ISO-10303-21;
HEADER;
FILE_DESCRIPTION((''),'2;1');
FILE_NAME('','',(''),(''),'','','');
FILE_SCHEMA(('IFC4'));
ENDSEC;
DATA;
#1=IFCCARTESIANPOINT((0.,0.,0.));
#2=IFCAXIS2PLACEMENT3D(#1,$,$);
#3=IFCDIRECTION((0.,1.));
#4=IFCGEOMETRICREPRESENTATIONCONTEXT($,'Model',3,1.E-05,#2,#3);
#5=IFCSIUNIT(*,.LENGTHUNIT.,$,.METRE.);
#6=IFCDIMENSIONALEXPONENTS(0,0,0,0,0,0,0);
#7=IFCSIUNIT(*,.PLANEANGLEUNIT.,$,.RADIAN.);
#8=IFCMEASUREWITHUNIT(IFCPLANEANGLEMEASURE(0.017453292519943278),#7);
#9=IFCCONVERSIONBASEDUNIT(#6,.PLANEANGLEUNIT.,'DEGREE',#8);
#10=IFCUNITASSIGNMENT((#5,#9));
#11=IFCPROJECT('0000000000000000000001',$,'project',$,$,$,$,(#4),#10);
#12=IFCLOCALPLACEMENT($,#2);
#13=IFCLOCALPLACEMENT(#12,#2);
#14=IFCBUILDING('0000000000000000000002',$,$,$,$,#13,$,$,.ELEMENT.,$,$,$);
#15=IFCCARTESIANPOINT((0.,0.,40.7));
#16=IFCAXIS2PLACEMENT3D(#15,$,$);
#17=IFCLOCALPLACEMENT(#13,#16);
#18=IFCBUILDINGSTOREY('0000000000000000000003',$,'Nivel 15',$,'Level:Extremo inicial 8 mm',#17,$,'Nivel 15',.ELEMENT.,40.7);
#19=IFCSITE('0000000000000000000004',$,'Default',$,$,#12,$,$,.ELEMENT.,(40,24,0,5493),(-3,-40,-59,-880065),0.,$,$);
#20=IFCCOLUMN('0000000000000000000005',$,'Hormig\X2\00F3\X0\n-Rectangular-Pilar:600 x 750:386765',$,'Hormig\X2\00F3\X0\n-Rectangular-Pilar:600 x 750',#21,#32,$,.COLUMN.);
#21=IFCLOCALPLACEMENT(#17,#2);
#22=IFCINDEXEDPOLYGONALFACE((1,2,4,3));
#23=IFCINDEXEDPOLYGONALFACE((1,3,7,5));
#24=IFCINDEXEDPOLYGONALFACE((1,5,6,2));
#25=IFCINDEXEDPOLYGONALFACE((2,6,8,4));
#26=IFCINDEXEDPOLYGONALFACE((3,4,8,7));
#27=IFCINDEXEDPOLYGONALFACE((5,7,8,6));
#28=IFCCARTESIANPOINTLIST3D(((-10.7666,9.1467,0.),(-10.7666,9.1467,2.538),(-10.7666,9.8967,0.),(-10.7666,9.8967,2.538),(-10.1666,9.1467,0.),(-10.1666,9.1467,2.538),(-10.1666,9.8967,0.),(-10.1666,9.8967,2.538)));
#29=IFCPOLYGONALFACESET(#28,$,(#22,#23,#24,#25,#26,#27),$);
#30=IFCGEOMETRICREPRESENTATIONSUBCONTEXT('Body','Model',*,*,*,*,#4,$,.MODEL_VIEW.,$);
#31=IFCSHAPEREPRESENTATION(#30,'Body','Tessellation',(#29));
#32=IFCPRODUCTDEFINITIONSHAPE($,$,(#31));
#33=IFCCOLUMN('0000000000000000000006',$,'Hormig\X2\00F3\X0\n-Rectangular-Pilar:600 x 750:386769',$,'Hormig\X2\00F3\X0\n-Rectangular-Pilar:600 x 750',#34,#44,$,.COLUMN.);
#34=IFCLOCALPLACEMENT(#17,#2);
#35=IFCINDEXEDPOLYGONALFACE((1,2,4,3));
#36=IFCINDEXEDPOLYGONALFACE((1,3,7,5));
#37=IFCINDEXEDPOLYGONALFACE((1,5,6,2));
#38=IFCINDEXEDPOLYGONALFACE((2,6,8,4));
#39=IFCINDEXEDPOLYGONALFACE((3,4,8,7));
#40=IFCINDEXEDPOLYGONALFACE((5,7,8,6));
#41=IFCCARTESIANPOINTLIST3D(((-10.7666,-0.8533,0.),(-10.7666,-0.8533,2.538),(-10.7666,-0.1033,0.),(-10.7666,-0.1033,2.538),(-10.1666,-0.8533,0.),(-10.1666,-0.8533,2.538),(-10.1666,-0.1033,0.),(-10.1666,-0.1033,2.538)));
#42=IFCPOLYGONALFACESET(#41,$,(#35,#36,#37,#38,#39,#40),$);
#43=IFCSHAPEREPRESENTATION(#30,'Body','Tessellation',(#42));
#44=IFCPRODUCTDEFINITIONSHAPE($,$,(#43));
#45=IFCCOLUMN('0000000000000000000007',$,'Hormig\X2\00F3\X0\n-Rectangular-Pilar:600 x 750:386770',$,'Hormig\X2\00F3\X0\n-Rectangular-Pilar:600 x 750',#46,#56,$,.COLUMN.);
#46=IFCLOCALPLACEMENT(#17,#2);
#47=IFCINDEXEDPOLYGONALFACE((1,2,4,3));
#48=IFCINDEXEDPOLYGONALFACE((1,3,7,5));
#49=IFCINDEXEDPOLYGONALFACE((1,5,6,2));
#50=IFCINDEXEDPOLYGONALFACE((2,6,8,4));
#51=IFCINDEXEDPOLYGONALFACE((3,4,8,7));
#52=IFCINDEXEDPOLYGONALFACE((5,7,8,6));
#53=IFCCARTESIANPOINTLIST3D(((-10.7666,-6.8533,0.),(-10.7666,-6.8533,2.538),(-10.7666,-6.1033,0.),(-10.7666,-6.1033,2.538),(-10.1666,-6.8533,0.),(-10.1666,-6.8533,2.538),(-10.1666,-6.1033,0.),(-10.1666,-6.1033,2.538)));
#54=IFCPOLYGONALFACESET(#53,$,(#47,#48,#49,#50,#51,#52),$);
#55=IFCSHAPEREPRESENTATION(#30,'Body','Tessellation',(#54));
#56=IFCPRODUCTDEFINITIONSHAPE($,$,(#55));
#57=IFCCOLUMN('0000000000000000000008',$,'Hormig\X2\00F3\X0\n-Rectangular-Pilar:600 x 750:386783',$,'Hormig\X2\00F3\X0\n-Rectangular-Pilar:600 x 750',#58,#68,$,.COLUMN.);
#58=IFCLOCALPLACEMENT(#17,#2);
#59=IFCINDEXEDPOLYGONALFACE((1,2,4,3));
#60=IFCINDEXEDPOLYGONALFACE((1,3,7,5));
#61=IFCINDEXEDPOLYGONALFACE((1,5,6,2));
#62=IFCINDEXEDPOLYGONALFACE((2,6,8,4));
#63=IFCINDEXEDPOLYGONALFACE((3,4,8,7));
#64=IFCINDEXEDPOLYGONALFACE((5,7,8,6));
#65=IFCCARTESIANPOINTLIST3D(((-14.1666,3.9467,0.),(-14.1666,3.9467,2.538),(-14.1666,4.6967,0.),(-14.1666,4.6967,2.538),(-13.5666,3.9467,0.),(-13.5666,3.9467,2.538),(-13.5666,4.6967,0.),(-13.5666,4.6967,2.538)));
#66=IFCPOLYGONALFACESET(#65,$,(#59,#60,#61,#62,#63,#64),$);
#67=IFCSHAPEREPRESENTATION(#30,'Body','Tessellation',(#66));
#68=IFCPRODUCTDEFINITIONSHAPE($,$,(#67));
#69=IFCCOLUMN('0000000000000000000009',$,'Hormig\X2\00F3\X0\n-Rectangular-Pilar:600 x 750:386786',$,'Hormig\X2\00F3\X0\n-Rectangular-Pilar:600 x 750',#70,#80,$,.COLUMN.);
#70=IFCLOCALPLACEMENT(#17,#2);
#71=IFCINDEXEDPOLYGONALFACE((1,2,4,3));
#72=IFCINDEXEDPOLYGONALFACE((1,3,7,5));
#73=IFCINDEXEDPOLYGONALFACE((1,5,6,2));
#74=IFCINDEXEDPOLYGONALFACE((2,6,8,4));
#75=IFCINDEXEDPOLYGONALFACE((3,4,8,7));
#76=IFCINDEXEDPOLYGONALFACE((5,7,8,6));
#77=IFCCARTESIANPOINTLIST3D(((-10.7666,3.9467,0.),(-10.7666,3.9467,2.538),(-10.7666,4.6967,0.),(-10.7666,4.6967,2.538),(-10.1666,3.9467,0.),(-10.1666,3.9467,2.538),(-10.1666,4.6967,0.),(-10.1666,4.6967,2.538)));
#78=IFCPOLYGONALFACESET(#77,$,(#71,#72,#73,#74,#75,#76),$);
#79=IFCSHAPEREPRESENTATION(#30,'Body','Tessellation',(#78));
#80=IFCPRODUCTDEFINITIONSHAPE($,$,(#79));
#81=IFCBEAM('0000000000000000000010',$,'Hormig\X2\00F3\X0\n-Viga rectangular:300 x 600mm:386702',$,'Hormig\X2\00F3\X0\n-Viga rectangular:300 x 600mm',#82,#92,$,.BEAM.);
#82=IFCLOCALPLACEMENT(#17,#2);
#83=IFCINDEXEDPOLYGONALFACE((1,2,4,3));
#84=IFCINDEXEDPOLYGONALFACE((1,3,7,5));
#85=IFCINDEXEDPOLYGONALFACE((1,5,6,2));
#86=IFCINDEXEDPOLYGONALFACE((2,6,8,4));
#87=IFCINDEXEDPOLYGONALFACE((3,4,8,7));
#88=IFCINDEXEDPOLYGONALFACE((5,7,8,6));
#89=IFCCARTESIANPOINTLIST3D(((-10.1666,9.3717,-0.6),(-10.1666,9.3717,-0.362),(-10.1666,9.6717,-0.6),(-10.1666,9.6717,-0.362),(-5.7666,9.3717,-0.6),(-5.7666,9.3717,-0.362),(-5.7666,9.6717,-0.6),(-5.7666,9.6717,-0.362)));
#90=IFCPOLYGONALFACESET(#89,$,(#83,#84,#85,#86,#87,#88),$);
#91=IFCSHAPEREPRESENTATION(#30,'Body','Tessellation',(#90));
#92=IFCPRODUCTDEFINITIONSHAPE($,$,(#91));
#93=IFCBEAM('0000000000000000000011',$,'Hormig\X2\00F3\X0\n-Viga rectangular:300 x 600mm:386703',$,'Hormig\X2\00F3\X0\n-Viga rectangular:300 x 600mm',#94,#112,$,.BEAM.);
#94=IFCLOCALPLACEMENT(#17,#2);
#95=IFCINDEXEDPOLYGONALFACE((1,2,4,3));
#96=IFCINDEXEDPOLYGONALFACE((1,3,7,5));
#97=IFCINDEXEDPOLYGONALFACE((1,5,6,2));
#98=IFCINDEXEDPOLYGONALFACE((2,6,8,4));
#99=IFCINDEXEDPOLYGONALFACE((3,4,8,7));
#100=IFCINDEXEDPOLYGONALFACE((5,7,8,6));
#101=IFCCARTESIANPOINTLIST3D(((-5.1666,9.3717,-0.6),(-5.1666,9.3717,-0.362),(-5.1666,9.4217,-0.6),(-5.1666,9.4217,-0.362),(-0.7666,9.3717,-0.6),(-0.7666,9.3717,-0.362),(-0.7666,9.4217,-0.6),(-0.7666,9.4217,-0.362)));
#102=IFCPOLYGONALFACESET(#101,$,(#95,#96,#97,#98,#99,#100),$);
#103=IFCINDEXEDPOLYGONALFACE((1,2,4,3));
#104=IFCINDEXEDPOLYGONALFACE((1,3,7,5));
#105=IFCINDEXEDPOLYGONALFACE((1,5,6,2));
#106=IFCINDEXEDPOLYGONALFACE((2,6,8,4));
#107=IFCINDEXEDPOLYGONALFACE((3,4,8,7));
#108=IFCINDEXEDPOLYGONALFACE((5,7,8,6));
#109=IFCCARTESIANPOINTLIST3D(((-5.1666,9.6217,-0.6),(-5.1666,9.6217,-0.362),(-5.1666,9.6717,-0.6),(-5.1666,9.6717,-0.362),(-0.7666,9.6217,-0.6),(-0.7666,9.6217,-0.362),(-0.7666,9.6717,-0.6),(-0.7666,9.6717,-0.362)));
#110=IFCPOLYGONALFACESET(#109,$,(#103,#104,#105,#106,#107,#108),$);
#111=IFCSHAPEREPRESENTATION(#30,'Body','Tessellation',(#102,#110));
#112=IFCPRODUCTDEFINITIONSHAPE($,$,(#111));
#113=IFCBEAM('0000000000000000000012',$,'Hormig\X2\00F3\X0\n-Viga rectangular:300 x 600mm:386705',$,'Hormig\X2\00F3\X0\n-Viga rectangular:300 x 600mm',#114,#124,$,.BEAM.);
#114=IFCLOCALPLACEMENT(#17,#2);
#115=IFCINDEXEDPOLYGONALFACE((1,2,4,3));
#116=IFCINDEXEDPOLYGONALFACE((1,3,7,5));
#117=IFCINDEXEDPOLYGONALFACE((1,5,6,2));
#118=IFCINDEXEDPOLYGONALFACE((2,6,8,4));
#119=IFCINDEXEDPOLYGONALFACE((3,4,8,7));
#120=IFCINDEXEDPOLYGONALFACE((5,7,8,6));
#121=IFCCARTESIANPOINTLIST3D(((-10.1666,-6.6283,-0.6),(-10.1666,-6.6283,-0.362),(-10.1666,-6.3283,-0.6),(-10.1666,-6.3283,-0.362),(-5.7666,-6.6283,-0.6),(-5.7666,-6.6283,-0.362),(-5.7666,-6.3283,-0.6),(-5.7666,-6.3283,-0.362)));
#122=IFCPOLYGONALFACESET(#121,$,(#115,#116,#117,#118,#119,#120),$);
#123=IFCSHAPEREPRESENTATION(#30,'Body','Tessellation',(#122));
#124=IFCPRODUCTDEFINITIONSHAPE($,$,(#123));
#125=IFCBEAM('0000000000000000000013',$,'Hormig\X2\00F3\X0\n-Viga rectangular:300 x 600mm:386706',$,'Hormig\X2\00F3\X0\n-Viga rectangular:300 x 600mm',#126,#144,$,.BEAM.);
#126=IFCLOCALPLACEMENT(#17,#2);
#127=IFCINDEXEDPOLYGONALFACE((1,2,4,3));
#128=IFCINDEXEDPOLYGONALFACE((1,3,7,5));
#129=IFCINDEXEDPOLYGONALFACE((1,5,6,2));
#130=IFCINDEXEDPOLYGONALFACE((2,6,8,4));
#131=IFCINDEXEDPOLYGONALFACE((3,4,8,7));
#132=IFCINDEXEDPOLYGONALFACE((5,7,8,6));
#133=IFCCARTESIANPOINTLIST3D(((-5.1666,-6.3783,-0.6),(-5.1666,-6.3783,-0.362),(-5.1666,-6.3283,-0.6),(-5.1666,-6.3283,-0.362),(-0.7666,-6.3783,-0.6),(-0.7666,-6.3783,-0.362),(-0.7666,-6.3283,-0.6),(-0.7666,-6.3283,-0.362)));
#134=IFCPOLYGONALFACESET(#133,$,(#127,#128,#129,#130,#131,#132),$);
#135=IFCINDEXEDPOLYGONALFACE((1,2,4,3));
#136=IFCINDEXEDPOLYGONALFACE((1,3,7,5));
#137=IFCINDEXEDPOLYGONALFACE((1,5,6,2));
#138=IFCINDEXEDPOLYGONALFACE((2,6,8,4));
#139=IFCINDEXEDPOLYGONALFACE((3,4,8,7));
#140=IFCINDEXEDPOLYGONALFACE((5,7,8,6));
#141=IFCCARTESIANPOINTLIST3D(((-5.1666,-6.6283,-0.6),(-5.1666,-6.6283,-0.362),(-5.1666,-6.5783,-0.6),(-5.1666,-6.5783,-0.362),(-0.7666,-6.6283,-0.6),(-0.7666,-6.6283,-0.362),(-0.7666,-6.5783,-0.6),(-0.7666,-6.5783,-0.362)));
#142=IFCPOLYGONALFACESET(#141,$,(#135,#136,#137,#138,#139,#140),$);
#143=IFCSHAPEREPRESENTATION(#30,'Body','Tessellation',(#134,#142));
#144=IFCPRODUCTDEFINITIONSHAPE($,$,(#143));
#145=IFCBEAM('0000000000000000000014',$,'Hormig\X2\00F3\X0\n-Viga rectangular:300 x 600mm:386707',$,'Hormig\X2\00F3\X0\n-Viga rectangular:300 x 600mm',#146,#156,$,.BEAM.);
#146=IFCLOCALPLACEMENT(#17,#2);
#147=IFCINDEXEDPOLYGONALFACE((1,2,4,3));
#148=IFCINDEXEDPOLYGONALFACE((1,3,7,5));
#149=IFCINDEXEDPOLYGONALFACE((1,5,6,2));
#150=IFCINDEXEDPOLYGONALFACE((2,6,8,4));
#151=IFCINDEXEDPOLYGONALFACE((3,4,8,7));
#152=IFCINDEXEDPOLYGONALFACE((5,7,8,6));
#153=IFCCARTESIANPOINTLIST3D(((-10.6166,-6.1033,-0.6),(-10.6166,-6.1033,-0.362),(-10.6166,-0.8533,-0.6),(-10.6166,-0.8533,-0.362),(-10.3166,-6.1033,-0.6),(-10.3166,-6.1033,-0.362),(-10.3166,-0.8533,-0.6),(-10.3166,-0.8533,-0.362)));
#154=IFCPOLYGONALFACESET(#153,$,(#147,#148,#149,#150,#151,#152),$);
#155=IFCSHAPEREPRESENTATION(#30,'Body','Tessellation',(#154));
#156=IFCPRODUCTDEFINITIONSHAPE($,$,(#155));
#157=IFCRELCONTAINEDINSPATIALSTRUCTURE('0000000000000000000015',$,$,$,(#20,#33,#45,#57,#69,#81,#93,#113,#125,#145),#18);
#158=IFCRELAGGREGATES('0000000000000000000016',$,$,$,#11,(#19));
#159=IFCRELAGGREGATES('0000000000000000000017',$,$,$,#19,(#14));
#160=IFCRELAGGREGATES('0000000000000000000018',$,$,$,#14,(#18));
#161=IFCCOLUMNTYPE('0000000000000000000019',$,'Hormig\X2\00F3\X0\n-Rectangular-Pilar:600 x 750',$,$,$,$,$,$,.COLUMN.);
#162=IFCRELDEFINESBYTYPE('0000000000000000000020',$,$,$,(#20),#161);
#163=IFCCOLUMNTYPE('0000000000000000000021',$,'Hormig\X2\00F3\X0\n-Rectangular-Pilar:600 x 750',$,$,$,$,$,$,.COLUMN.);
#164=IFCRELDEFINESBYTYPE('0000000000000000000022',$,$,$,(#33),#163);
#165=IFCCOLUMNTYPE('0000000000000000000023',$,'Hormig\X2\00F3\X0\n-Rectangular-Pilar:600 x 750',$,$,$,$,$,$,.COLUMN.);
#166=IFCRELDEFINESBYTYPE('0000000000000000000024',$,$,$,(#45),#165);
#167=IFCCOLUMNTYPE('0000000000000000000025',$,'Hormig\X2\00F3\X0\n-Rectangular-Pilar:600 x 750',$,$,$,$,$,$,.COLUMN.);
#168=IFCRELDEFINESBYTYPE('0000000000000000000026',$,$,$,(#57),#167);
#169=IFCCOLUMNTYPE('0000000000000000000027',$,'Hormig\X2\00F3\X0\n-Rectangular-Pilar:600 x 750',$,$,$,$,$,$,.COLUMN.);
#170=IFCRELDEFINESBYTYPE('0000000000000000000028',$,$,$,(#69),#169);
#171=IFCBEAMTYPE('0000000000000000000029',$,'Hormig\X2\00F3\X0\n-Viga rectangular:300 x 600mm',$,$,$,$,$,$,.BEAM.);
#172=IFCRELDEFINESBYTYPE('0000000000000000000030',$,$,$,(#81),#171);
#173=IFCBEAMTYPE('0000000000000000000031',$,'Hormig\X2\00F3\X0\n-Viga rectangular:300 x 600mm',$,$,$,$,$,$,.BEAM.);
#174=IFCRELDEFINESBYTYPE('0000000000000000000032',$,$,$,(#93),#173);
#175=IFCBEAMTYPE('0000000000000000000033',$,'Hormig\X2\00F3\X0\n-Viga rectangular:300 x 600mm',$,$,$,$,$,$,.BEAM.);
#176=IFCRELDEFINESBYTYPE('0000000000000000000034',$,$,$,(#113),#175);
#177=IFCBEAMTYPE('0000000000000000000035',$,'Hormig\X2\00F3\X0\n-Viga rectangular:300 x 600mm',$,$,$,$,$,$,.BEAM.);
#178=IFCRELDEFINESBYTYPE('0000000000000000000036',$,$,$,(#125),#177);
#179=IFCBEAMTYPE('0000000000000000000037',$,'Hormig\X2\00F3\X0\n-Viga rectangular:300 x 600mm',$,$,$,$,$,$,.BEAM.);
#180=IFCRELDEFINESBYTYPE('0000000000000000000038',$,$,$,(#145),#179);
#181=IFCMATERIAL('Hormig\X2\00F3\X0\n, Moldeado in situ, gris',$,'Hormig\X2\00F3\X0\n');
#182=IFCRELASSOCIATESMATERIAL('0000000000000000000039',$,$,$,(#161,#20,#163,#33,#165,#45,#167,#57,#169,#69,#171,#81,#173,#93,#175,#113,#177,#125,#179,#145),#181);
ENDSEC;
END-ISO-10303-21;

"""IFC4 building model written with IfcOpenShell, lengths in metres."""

from ifc_helpers import new_model, entity, si_unit, converted_unit, direction, frame, origin, place, context, subcontext, project, spatial, indexed_curve, outline, extrude, source, transform, mapped, material, type_object, type_shapes, element, save


model = new_model("IFC4")

# Units and contexts
model_context = context("Model", 3, precision=1e-05, world=origin(), true_north=direction((0.0, 1.0)))
body_context = subcontext(model_context, "Body", "Model", "MODEL_VIEW")
ifc_project = project(units=[si_unit("LENGTHUNIT", "METRE"), converted_unit("PLANEANGLEUNIT", "DEGREE", entity("IfcPlaneAngleMeasure", 0.017453292519943278), si_unit("PLANEANGLEUNIT", "RADIAN"), dimensions=[0, 0, 0, 0, 0, 0, 0])], contexts=[model_context])

# Site, building, storey
site_placement = place(None, origin())
site = spatial("IfcSite", under=ifc_project, at=site_placement, Name="Default", CompositionType="ELEMENT", RefLatitude=(40, 24, 0, 5493), RefLongitude=(-3, -40, -59, -880065), RefElevation=0.0)
building_placement = place(site_placement, origin())
building = spatial("IfcBuilding", under=site, at=building_placement, CompositionType="ELEMENT")
storey_placement = place(building_placement, frame((0.0, 0.0, 40.7)))
storey = spatial("IfcBuildingStorey", under=building, at=storey_placement, Name="Nivel 15", ObjectType="Level:Extremo inicial 8 mm", LongName="Nivel 15", CompositionType="ELEMENT", Elevation=40.7)

# Columns
ifc_material_1 = material(Name="Hormigón, Moldeado in situ, gris", Category="Hormigón")
column_type_1 = type_object("IfcColumnType", Name="Hormigón-Rectangular-Pilar:600 x 750", PredefinedType="COLUMN", material=ifc_material_1)
shared_shape_1 = source(origin(), body_context, "Body", "SweptSolid", [
    extrude(outline(indexed_curve([(-0.3, -0.375), (0.3, -0.375), (0.3, 0.375), (-0.3, 0.375), (-0.3, -0.375)], self_intersect=False)), frame((-10.4666, 9.5217, 40.7), z_axis=(0.0, 0.0, 1.0), x_axis=(-1.0, 0.0, 0.0)), (0.0, 0.0, 1.0), 2.538),
])
type_shapes(column_type_1, [shared_shape_1])
column_1_placement = place(storey_placement, frame((0.0, 0.0, -40.7)))
element("IfcColumn", 1, at=column_1_placement, inside=storey, type_object=column_type_1, material=ifc_material_1, Name="Hormigón-Rectangular-Pilar:600 x 750:386765", ObjectType="Hormigón-Rectangular-Pilar:600 x 750", PredefinedType="COLUMN", context=body_context, shape_type="MappedRepresentation", body=[
    mapped(shared_shape_1, transform((0.0, 0.0, 0.0), scale=1.0)),
])
column_type_2 = type_object("IfcColumnType", Name="Hormigón-Rectangular-Pilar:600 x 750", PredefinedType="COLUMN", material=ifc_material_1)
shared_shape_2 = source(origin(), body_context, "Body", "SweptSolid", [
    extrude(outline(indexed_curve([(-0.3, -0.375), (0.3, -0.375), (0.3, 0.375), (-0.3, 0.375), (-0.3, -0.375)], self_intersect=False)), frame((-10.4666, -0.4783, 40.7), z_axis=(0.0, 0.0, 1.0), x_axis=(-1.0, 0.0, 0.0)), (0.0, 0.0, 1.0), 2.538),
])
type_shapes(column_type_2, [shared_shape_2])
column_2_placement = place(storey_placement, frame((0.0, 0.0, -40.7)))
element("IfcColumn", 2, at=column_2_placement, inside=storey, type_object=column_type_2, material=ifc_material_1, Name="Hormigón-Rectangular-Pilar:600 x 750:386769", ObjectType="Hormigón-Rectangular-Pilar:600 x 750", PredefinedType="COLUMN", context=body_context, shape_type="MappedRepresentation", body=[
    mapped(shared_shape_2, transform((0.0, 0.0, 0.0), scale=1.0)),
])
column_type_3 = type_object("IfcColumnType", Name="Hormigón-Rectangular-Pilar:600 x 750", PredefinedType="COLUMN", material=ifc_material_1)
shared_shape_3 = source(origin(), body_context, "Body", "SweptSolid", [
    extrude(outline(indexed_curve([(-0.3, -0.375), (0.3, -0.375), (0.3, 0.375), (-0.3, 0.375), (-0.3, -0.375)], self_intersect=False)), frame((-10.4666, -6.4783, 40.7), z_axis=(0.0, 0.0, 1.0), x_axis=(-1.0, 0.0, 0.0)), (0.0, 0.0, 1.0), 2.538),
])
type_shapes(column_type_3, [shared_shape_3])
column_3_placement = place(storey_placement, frame((0.0, 0.0, -40.7)))
element("IfcColumn", 3, at=column_3_placement, inside=storey, type_object=column_type_3, material=ifc_material_1, Name="Hormigón-Rectangular-Pilar:600 x 750:386770", ObjectType="Hormigón-Rectangular-Pilar:600 x 750", PredefinedType="COLUMN", context=body_context, shape_type="MappedRepresentation", body=[
    mapped(shared_shape_3, transform((0.0, 0.0, 0.0), scale=1.0)),
])
column_type_4 = type_object("IfcColumnType", Name="Hormigón-Rectangular-Pilar:600 x 750", PredefinedType="COLUMN", material=ifc_material_1)
shared_shape_4 = source(origin(), body_context, "Body", "SweptSolid", [
    extrude(outline(indexed_curve([(-0.3, -0.375), (0.3, -0.375), (0.3, 0.375), (-0.3, 0.375), (-0.3, -0.375)], self_intersect=False)), frame((-13.8666, 4.3217, 40.7), z_axis=(0.0, 0.0, 1.0), x_axis=(-1.0, 0.0, 0.0)), (0.0, 0.0, 1.0), 2.538),
])
type_shapes(column_type_4, [shared_shape_4])
column_4_placement = place(storey_placement, frame((0.0, 0.0, -40.7)))
element("IfcColumn", 4, at=column_4_placement, inside=storey, type_object=column_type_4, material=ifc_material_1, Name="Hormigón-Rectangular-Pilar:600 x 750:386783", ObjectType="Hormigón-Rectangular-Pilar:600 x 750", PredefinedType="COLUMN", context=body_context, shape_type="MappedRepresentation", body=[
    mapped(shared_shape_4, transform((0.0, 0.0, 0.0), scale=1.0)),
])
column_type_5 = type_object("IfcColumnType", Name="Hormigón-Rectangular-Pilar:600 x 750", PredefinedType="COLUMN", material=ifc_material_1)
shared_shape_5 = source(origin(), body_context, "Body", "SweptSolid", [
    extrude(outline(indexed_curve([(-0.3, -0.375), (0.3, -0.375), (0.3, 0.375), (-0.3, 0.375), (-0.3, -0.375)], self_intersect=False)), frame((-10.4666, 4.3217, 40.7), z_axis=(0.0, 0.0, 1.0), x_axis=(-1.0, 0.0, 0.0)), (0.0, 0.0, 1.0), 2.538),
])
type_shapes(column_type_5, [shared_shape_5])
column_5_placement = place(storey_placement, frame((0.0, 0.0, -40.7)))
element("IfcColumn", 5, at=column_5_placement, inside=storey, type_object=column_type_5, material=ifc_material_1, Name="Hormigón-Rectangular-Pilar:600 x 750:386786", ObjectType="Hormigón-Rectangular-Pilar:600 x 750", PredefinedType="COLUMN", context=body_context, shape_type="MappedRepresentation", body=[
    mapped(shared_shape_5, transform((0.0, 0.0, 0.0), scale=1.0)),
])

# Beams
beam_type_1 = type_object("IfcBeamType", Name="Hormigón-Viga rectangular:300 x 600mm", PredefinedType="BEAM", material=ifc_material_1)
shared_shape_6 = source(origin(), body_context, "Body", "SweptSolid", [
    extrude(outline(indexed_curve([(-0.119, -0.15), (0.119, -0.15), (0.119, 0.15), (-0.119, 0.15), (-0.119, -0.15)], self_intersect=False)), frame((-5.7666, 9.5217, 40.219), z_axis=(-1.0, 0.0, 0.0), x_axis=(0.0, 0.0, -1.0)), (0.0, 0.0, 1.0), 4.4),
])
type_shapes(beam_type_1, [shared_shape_6])
beam_1_placement = place(storey_placement, frame((0.0, 0.0, -40.7)))
element("IfcBeam", 6, at=beam_1_placement, inside=storey, type_object=beam_type_1, material=ifc_material_1, Name="Hormigón-Viga rectangular:300 x 600mm:386702", ObjectType="Hormigón-Viga rectangular:300 x 600mm", PredefinedType="BEAM", context=body_context, shape_type="MappedRepresentation", body=[
    mapped(shared_shape_6, transform((0.0, 0.0, 0.0), scale=1.0)),
])
beam_type_2 = type_object("IfcBeamType", Name="Hormigón-Viga rectangular:300 x 600mm", PredefinedType="BEAM", material=ifc_material_1)
shared_shape_7 = source(origin(), body_context, "Body", "SweptSolid", [
    extrude(outline(indexed_curve([(-0.119, -0.025), (0.119, -0.025), (0.119, 0.025), (-0.119, 0.025), (-0.119, -0.025)], self_intersect=False)), frame((-5.1666, 9.3967, 40.219), z_axis=(1.0, 0.0, 0.0), x_axis=(0.0, 0.0, -1.0)), (0.0, 0.0, 1.0), 4.4),
    extrude(outline(indexed_curve([(-0.119, -0.025), (0.119, -0.025), (0.119, 0.025), (-0.119, 0.025), (-0.119, -0.025)], self_intersect=False)), frame((-5.1666, 9.6467, 40.219), z_axis=(1.0, 0.0, 0.0), x_axis=(0.0, 0.0, -1.0)), (0.0, 0.0, 1.0), 4.4),
])
type_shapes(beam_type_2, [shared_shape_7])
beam_2_placement = place(storey_placement, frame((0.0, 0.0, -40.7)))
element("IfcBeam", 7, at=beam_2_placement, inside=storey, type_object=beam_type_2, material=ifc_material_1, Name="Hormigón-Viga rectangular:300 x 600mm:386703", ObjectType="Hormigón-Viga rectangular:300 x 600mm", PredefinedType="BEAM", context=body_context, shape_type="MappedRepresentation", body=[
    mapped(shared_shape_7, transform((0.0, 0.0, 0.0), scale=1.0)),
])
beam_type_3 = type_object("IfcBeamType", Name="Hormigón-Viga rectangular:300 x 600mm", PredefinedType="BEAM", material=ifc_material_1)
shared_shape_8 = source(origin(), body_context, "Body", "SweptSolid", [
    extrude(outline(indexed_curve([(-0.119, -0.15), (0.119, -0.15), (0.119, 0.15), (-0.119, 0.15), (-0.119, -0.15)], self_intersect=False)), frame((-10.1666, -6.4783, 40.219), z_axis=(1.0, 0.0, 0.0), x_axis=(0.0, 0.0, -1.0)), (0.0, 0.0, 1.0), 4.4),
])
type_shapes(beam_type_3, [shared_shape_8])
beam_3_placement = place(storey_placement, frame((0.0, 0.0, -40.7)))
element("IfcBeam", 8, at=beam_3_placement, inside=storey, type_object=beam_type_3, material=ifc_material_1, Name="Hormigón-Viga rectangular:300 x 600mm:386705", ObjectType="Hormigón-Viga rectangular:300 x 600mm", PredefinedType="BEAM", context=body_context, shape_type="MappedRepresentation", body=[
    mapped(shared_shape_8, transform((0.0, 0.0, 0.0), scale=1.0)),
])
beam_type_4 = type_object("IfcBeamType", Name="Hormigón-Viga rectangular:300 x 600mm", PredefinedType="BEAM", material=ifc_material_1)
shared_shape_9 = source(origin(), body_context, "Body", "SweptSolid", [
    extrude(outline(indexed_curve([(-0.119, -0.025), (0.119, -0.025), (0.119, 0.025), (-0.119, 0.025), (-0.119, -0.025)], self_intersect=False)), frame((-0.7666, -6.3533, 40.219), z_axis=(-1.0, 0.0, 0.0), x_axis=(0.0, 0.0, -1.0)), (0.0, 0.0, 1.0), 4.4),
    extrude(outline(indexed_curve([(-0.119, -0.025), (0.119, -0.025), (0.119, 0.025), (-0.119, 0.025), (-0.119, -0.025)], self_intersect=False)), frame((-0.7666, -6.6033, 40.219), z_axis=(-1.0, 0.0, 0.0), x_axis=(0.0, 0.0, -1.0)), (0.0, 0.0, 1.0), 4.4),
])
type_shapes(beam_type_4, [shared_shape_9])
beam_4_placement = place(storey_placement, frame((0.0, 0.0, -40.7)))
element("IfcBeam", 9, at=beam_4_placement, inside=storey, type_object=beam_type_4, material=ifc_material_1, Name="Hormigón-Viga rectangular:300 x 600mm:386706", ObjectType="Hormigón-Viga rectangular:300 x 600mm", PredefinedType="BEAM", context=body_context, shape_type="MappedRepresentation", body=[
    mapped(shared_shape_9, transform((0.0, 0.0, 0.0), scale=1.0)),
])
beam_type_5 = type_object("IfcBeamType", Name="Hormigón-Viga rectangular:300 x 600mm", PredefinedType="BEAM", material=ifc_material_1)
shared_shape_10 = source(origin(), body_context, "Body", "SweptSolid", [
    extrude(outline(indexed_curve([(-0.15, -0.119), (0.15, -0.119), (0.15, 0.119), (-0.15, 0.119), (-0.15, -0.119)], self_intersect=False)), frame((-10.4666, -6.1033, 40.219), z_axis=(0.0, 1.0, 0.0), x_axis=(-1.0, 0.0, 0.0)), (0.0, 0.0, 1.0), 5.25),
])
type_shapes(beam_type_5, [shared_shape_10])
beam_5_placement = place(storey_placement, frame((0.0, 0.0, -40.7)))
element("IfcBeam", 10, at=beam_5_placement, inside=storey, type_object=beam_type_5, material=ifc_material_1, Name="Hormigón-Viga rectangular:300 x 600mm:386707", ObjectType="Hormigón-Viga rectangular:300 x 600mm", PredefinedType="BEAM", context=body_context, shape_type="MappedRepresentation", body=[
    mapped(shared_shape_10, transform((0.0, 0.0, 0.0), scale=1.0)),
])

save(model, "model.ifc")
